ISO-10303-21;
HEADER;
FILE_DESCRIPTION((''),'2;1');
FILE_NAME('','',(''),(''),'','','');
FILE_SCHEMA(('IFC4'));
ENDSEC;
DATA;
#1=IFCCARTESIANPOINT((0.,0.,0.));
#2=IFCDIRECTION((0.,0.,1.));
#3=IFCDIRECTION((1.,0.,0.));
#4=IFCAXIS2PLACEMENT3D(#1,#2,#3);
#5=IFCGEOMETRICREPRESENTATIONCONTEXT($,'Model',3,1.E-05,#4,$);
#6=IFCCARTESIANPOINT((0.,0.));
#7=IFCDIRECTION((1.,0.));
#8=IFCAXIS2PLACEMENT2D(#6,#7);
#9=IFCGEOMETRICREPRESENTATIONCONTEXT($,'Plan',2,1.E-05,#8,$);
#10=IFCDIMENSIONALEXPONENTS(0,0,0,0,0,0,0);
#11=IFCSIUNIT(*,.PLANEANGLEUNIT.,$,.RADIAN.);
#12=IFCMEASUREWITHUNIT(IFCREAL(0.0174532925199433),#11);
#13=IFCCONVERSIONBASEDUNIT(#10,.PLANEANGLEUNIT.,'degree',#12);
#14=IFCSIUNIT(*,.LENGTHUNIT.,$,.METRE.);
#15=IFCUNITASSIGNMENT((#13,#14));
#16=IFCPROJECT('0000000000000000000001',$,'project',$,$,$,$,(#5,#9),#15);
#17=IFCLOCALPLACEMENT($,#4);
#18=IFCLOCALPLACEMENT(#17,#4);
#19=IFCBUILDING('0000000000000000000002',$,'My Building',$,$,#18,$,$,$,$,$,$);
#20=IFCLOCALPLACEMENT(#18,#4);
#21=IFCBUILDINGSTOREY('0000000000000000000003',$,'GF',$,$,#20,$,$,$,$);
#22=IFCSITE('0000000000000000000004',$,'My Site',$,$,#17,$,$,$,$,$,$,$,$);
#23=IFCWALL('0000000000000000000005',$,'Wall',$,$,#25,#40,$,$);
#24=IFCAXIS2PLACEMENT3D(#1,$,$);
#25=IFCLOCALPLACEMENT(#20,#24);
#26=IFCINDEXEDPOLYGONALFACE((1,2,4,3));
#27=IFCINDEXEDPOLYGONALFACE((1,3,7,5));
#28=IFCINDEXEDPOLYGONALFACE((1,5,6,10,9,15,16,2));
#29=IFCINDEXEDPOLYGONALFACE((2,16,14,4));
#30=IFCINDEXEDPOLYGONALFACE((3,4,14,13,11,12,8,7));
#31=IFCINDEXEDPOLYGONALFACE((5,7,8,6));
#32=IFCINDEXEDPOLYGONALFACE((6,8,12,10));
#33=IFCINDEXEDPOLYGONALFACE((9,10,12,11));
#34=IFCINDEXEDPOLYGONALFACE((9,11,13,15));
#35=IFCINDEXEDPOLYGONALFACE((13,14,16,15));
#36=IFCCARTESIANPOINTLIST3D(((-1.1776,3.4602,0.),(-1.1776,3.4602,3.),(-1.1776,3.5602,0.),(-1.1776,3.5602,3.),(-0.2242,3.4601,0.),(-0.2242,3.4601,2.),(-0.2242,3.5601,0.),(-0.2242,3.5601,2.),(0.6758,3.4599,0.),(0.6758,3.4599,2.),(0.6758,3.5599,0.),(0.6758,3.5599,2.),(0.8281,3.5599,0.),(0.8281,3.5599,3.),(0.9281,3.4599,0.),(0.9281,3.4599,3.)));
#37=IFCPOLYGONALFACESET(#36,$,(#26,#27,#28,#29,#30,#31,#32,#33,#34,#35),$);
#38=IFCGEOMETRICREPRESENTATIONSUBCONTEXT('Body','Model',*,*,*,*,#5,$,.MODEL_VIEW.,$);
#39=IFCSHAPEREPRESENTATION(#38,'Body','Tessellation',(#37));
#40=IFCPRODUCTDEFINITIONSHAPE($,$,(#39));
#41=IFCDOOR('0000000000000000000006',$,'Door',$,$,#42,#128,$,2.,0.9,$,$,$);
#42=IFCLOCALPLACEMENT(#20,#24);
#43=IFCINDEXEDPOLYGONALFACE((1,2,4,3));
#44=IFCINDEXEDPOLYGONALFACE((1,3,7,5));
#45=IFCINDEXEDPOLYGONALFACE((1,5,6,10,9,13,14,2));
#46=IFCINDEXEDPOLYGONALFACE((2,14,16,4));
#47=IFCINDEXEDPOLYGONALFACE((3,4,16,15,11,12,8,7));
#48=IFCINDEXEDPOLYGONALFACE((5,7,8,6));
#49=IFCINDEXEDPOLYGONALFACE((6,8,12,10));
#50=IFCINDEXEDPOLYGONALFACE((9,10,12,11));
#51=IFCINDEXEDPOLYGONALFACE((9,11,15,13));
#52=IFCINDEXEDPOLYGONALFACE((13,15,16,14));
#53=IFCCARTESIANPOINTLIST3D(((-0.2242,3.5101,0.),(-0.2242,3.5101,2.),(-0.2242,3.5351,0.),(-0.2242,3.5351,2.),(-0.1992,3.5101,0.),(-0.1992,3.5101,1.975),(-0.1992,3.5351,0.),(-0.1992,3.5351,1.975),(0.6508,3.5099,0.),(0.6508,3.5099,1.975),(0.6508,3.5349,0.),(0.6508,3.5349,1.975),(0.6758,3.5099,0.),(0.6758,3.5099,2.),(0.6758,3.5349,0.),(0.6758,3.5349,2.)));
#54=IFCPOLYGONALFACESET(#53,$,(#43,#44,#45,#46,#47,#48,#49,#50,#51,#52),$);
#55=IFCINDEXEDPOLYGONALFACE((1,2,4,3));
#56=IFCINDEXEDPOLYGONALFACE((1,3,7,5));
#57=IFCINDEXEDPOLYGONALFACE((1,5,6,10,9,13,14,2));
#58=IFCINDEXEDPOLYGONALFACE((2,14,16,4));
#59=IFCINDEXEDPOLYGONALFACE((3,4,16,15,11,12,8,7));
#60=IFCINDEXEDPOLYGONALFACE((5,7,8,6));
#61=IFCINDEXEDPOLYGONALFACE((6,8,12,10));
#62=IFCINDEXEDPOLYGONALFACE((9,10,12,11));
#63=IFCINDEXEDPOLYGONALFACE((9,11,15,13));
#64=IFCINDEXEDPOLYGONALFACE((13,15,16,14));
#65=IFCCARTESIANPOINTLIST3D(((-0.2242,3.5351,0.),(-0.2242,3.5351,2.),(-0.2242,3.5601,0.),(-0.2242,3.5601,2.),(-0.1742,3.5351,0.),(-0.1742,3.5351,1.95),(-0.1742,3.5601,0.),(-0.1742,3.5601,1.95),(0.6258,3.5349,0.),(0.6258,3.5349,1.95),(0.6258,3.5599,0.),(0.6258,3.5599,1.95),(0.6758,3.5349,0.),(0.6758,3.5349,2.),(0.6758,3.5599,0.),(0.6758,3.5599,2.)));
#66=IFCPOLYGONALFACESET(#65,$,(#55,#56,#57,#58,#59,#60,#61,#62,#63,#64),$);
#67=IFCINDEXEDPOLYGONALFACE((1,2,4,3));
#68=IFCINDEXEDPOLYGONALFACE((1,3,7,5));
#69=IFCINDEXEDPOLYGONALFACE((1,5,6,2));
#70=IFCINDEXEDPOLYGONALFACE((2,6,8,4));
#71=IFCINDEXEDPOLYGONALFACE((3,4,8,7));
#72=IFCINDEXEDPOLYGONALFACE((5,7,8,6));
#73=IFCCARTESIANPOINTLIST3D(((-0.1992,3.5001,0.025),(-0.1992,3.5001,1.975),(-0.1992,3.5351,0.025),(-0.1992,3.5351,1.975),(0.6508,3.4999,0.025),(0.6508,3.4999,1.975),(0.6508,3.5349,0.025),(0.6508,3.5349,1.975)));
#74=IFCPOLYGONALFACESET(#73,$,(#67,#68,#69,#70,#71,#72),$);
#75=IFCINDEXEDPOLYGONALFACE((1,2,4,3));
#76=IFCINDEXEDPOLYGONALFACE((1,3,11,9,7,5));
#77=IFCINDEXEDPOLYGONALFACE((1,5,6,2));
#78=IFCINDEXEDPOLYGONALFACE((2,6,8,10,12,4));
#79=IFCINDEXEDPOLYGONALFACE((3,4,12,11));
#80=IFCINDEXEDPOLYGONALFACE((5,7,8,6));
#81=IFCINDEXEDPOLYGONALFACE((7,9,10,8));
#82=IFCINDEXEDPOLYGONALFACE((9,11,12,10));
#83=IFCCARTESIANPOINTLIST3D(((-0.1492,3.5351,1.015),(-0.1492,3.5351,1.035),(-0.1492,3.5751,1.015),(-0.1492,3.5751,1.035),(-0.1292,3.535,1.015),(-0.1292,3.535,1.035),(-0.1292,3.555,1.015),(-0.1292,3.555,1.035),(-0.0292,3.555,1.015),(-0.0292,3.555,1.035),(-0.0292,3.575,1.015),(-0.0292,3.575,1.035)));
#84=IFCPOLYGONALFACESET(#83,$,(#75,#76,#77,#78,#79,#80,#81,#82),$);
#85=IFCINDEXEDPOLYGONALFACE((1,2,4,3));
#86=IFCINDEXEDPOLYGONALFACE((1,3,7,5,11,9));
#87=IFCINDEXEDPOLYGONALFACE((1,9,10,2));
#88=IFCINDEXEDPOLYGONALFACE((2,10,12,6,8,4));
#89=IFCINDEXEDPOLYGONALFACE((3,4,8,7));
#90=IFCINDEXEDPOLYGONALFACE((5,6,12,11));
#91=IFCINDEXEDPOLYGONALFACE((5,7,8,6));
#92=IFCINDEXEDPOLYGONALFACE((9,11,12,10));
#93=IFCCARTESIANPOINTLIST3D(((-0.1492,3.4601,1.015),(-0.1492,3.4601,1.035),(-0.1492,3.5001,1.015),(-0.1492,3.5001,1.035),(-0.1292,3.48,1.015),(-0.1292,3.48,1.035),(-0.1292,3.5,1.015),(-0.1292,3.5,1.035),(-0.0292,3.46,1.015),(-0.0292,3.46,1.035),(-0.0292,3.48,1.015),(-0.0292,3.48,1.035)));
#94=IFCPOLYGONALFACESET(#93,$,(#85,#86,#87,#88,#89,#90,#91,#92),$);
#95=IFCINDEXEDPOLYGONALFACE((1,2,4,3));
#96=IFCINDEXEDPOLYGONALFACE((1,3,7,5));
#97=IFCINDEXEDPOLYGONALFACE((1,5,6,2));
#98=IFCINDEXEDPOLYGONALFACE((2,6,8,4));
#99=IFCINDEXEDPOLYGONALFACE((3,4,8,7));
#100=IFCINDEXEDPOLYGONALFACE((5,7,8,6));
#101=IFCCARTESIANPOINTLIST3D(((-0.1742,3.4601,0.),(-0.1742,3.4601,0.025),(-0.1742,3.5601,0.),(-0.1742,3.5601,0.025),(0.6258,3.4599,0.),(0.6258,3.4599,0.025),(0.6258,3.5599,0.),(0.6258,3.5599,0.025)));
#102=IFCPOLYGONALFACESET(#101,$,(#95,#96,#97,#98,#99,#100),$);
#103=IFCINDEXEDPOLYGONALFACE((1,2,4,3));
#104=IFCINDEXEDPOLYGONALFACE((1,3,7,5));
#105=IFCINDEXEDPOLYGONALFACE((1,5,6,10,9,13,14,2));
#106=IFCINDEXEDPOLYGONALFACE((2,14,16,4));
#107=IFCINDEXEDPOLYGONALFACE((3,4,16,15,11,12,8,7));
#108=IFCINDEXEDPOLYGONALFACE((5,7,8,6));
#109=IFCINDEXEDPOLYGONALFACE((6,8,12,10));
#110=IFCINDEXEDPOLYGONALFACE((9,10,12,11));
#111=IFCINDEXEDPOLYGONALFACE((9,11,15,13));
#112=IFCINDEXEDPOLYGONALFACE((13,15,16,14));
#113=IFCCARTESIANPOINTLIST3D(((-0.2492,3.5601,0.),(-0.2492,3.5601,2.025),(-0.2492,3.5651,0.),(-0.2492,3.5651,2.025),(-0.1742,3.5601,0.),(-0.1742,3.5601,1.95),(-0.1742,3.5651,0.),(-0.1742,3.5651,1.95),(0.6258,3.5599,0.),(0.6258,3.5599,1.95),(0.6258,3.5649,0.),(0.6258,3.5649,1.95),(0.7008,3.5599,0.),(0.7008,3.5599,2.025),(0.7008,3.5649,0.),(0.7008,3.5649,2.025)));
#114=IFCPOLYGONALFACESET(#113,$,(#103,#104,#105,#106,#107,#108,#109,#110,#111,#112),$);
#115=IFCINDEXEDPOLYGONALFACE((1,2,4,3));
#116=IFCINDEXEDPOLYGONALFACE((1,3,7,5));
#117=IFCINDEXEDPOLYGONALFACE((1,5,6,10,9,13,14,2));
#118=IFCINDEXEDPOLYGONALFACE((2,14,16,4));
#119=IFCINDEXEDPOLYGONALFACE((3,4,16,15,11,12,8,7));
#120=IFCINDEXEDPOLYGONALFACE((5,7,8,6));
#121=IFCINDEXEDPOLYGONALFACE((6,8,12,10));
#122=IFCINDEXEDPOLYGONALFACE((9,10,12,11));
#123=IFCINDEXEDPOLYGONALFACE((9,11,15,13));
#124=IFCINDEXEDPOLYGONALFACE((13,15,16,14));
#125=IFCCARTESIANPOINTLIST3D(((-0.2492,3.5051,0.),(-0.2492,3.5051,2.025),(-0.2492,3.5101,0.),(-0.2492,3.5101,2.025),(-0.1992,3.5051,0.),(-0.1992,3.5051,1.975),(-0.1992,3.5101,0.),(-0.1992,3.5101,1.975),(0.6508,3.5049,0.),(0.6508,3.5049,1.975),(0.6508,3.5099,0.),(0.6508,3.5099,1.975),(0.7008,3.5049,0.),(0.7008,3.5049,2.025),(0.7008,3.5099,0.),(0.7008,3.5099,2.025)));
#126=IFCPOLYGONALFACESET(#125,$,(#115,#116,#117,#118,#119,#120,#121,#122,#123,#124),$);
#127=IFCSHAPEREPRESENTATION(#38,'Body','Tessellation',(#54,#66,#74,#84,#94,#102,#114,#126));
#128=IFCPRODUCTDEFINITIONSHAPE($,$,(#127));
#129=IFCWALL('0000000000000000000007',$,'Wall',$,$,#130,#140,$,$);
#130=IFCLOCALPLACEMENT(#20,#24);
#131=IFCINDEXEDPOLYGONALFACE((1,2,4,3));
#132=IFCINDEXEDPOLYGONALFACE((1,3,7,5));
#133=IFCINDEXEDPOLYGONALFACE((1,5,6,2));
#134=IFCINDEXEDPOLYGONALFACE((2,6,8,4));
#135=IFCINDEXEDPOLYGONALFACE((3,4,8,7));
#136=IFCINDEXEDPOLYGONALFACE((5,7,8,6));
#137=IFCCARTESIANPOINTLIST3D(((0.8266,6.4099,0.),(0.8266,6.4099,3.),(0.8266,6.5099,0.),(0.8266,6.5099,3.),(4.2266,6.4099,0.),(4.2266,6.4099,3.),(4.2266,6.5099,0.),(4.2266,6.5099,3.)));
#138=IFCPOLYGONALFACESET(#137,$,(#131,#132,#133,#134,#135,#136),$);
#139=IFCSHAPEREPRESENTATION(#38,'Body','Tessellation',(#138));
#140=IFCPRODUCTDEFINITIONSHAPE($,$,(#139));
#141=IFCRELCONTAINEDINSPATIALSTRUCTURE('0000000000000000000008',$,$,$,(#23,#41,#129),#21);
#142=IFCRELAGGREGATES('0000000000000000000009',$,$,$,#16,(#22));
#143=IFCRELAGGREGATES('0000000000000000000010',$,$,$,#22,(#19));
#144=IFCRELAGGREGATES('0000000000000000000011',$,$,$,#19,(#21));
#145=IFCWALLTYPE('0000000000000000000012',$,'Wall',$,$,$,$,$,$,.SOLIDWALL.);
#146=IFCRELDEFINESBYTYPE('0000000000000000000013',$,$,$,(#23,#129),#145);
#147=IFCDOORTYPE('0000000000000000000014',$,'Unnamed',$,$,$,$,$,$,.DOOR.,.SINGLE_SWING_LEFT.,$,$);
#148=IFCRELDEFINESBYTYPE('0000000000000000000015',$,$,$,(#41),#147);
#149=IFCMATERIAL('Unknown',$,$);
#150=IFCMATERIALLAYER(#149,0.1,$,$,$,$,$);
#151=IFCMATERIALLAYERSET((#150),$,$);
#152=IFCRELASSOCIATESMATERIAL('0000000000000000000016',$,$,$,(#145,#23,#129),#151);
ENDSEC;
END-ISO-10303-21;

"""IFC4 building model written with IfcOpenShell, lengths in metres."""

from ifc_helpers import new_model, entity, si_unit, converted_unit, frame, origin_with_axes, origin_2d_with_axis, place, context, subcontext, project, spatial, line, indexed_curve, outline, extrude, shape, source, transform, mapped, material, layer, layer_set, layer_usage, type_object, type_shapes, element, fill, save


model = new_model("IFC4")

# Units and contexts
model_context = context("Model", 3, precision=1e-05, world=origin_with_axes())
plan_context = context("Plan", 2, precision=1e-05, world=origin_2d_with_axis())
body_context_1 = subcontext(model_context, "Body", "Model", "MODEL_VIEW")
body_context_2 = subcontext(plan_context, "Body", "Plan", "PLAN_VIEW")
ifc_project = project(units=[converted_unit("PLANEANGLEUNIT", "degree", entity("IfcReal", 0.0174532925199433), si_unit("PLANEANGLEUNIT", "RADIAN"), dimensions=[0, 0, 0, 0, 0, 0, 0]), si_unit("LENGTHUNIT", "METRE")], contexts=[model_context, plan_context])

# Site, building, storey
site_placement = place(None, origin_with_axes())
site = spatial("IfcSite", under=ifc_project, at=site_placement, Name="My Site")
building_placement = place(site_placement, origin_with_axes())
building = spatial("IfcBuilding", under=site, at=building_placement, Name="My Building")
storey_placement = place(building_placement, origin_with_axes())
storey = spatial("IfcBuildingStorey", under=building, at=storey_placement, Name="GF")

# Shared definitions
ifc_material = material(Name="Unknown")

# Shared definitions
ifc_layer_1 = layer(ifc_material, 0.1)
ifc_layer_set_1 = layer_set([ifc_layer_1])
wall_type = type_object("IfcWallType", Name="Wall", PredefinedType="SOLIDWALL", material=ifc_layer_set_1)
shared_shape_1 = source(origin_with_axes(), body_context_1, "Body", "SweptSolid", [
    extrude(outline(indexed_curve([(0.0, 0.0), (0.9, 0.0), (0.9, 2.0), (0.0, 2.0)], segments=[line(1, 2, 3, 4, 1)])), frame((0.0, -0.6, 0.0), z_axis=(0.0, -1.0, 0.0), x_axis=(1.0, 0.0, 0.0)), (0.0, 0.0, -1.0), 1.2),
])
door_type = type_object("IfcDoorType", Name="Unnamed", OperationType="SINGLE_SWING_LEFT", PredefinedType="DOOR")
shared_shape_2 = source(origin_with_axes(), body_context_1, "Body", "SweptSolid", [
    extrude(outline(indexed_curve([(0.0, 0.0), (0.0, 2.0), (0.9, 2.0), (0.9, 0.0), (0.875, 0.0), (0.875, 1.975), (0.025, 1.975), (0.025, 0.0)], segments=[line(1, 2, 3, 4, 5, 6, 7, 8, 1)])), frame((0.0, 0.025, 0.0), z_axis=(0.0, -1.0, 0.0), x_axis=(1.0, 0.0, 0.0)), (0.0, 0.0, -1.0), 0.025),
    extrude(outline(indexed_curve([(0.0, 0.0), (0.0, 2.0), (0.9, 2.0), (0.9, 0.0), (0.85, 0.0), (0.85, 1.95), (0.05, 1.95), (0.05, 0.0)], segments=[line(1, 2, 3, 4, 5, 6, 7, 8, 1)])), frame((0.0, 0.0, 0.0), z_axis=(0.0, -1.0, 0.0), x_axis=(1.0, 0.0, 0.0)), (0.0, 0.0, -1.0), 0.025),
    extrude(outline(indexed_curve([(0.0, 0.0), (0.85, 0.0), (0.85, 0.035), (0.0, 0.035)], segments=[line(1, 2, 3, 4, 1)])), frame((0.025, 0.025, 0.025), z_axis=(0.0, 0.0, 1.0), x_axis=(1.0, 0.0, 0.0)), (0.0, 0.0, 1.0), 1.95),
    extrude(outline(indexed_curve([(0.0, 0.0), (0.0, -0.04), (-0.12, -0.04), (-0.12, -0.02), (-0.02, -0.02), (-0.02, 0.0)], segments=[line(1, 2, 3, 4, 5, 6, 1)])), frame((0.825, 0.025, 1.015), z_axis=(0.0, 0.0, 1.0), x_axis=(1.0, 0.0, 0.0)), (0.0, 0.0, 1.0), 0.02),
    extrude(outline(indexed_curve([(0.0, 0.0), (0.0, 0.04), (-0.12, 0.04), (-0.12, 0.02), (-0.02, 0.02), (-0.02, 0.0)], segments=[line(1, 2, 3, 4, 5, 6, 1)])), frame((0.825, 0.06, 1.015), z_axis=(0.0, 0.0, 1.0), x_axis=(1.0, 0.0, 0.0)), (0.0, 0.0, 1.0), 0.02),
    extrude(outline(indexed_curve([(0.0, 0.0), (0.8, 0.0), (0.8, 0.1), (0.0, 0.1)], segments=[line(1, 2, 3, 4, 1)])), frame((0.05, 0.0, 0.0), z_axis=(0.0, 0.0, 1.0), x_axis=(1.0, 0.0, 0.0)), (0.0, 0.0, 1.0), 0.025),
    extrude(outline(indexed_curve([(0.0, 0.0), (0.0, 2.025), (0.95, 2.025), (0.95, 0.0), (0.875, 0.0), (0.875, 1.95), (0.075, 1.95), (0.075, 0.0)], segments=[line(1, 2, 3, 4, 5, 6, 7, 8, 1)])), frame((-0.025, -0.005, 0.0), z_axis=(0.0, -1.0, 0.0), x_axis=(1.0, 0.0, 0.0)), (0.0, 0.0, -1.0), 0.005),
    extrude(outline(indexed_curve([(0.0, 0.0), (0.0, 2.025), (0.95, 2.025), (0.95, 0.0), (0.9, 0.0), (0.9, 1.975), (0.05, 1.975), (0.05, 0.0)], segments=[line(1, 2, 3, 4, 5, 6, 7, 8, 1)])), frame((-0.025, 0.05, 0.0), z_axis=(0.0, -1.0, 0.0), x_axis=(1.0, 0.0, 0.0)), (0.0, 0.0, -1.0), 0.005),
])
shared_shape_3 = source(origin_with_axes(), body_context_2, "Body", "Curve2D", [
    entity("IfcIndexedPolyCurve", entity("IfcCartesianPointList2D", [[0.0, 0.0], [0.0, 0.05], [0.025, 0.05], [0.025, 0.025], [0.05, 0.025], [0.05, 0.0]]), [entity("IfcLineIndex", [1, 2, 3, 4, 5, 6, 1])]),
    entity("IfcIndexedPolyCurve", entity("IfcCartesianPointList2D", [[0.9, 0.0], [0.9, 0.05], [0.875, 0.05], [0.875, 0.025], [0.85, 0.025], [0.85, 0.0]]), [entity("IfcLineIndex", [1, 2, 3, 4, 5, 6, 1])]),
    entity("IfcTrimmedCurve", entity("IfcEllipse", entity("IfcAxis2Placement2D", entity("IfcCartesianPoint", [0.06, 0.05]), entity("IfcDirection", [1.0, 0.0])), 0.815, 0.85), [entity("IfcCartesianPoint", [0.875, 0.05])], [entity("IfcCartesianPoint", [0.06, 0.9])], True, "CARTESIAN"),
    entity("IfcIndexedPolyCurve", entity("IfcCartesianPointList2D", [[0.025, 0.05], [0.06, 0.05], [0.06, 0.9], [0.025, 0.9]]), [entity("IfcLineIndex", [1, 2, 3, 4, 1])]),
])
type_shapes(door_type, [shared_shape_2, shared_shape_3])

# Wall, opening, door
ifc_layer_usage_1 = layer_usage(ifc_layer_set_1, "AXIS2", "POSITIVE", 0.0)
wall_1_placement = place(storey_placement, frame((0.8281, 3.5599, 0.0), z_axis=(0.0, 0.0, 1.0), x_axis=(-1.0, 0.000162, 0.0)))
wall_1 = element("IfcWall", 1, at=wall_1_placement, inside=storey, type_object=wall_type, material=ifc_layer_usage_1, Name="Wall", context=body_context_1, shape_type="SweptSolid", body=[
    extrude(outline(indexed_curve([(0.0, 0.0), (-0.1, 0.1), (2.0056, 0.1), (2.0056, 0.0)], segments=[line(1, 2, 3, 4, 1)])), origin_with_axes(), (0.0, 0.0, 1.0), 3.0),
])
opening_1_placement = place(wall_1_placement, frame((0.1523, 0.0, 0.0), z_axis=(0.0, 0.0, 1.0), x_axis=(1.0, 0.0, 0.0)))
opening_1 = element("IfcOpeningElement", 2, at=opening_1_placement, cuts=wall_1, PredefinedType="OPENING", context=body_context_1, shape_type="MappedRepresentation", body=[
    mapped(shared_shape_1, transform((0.0, 0.0, 0.0), x_axis=(1.0, 0.0, 0.0), y_axis=(0.0, 1.0, 0.0), z_axis=(0.0, 0.0, 1.0), scale=1.0)),
])
door_1_placement = place(opening_1_placement, frame((0.0, 0.0, 0.0), z_axis=(0.0, 0.0, 1.0), x_axis=(1.0, 0.0, 0.0)))
door_1 = element("IfcDoor", 3, at=door_1_placement, inside=storey, type_object=door_type, Name="Door", OverallHeight=2.0, OverallWidth=0.9, shapes=[
    shape(body_context_1, "Body", "MappedRepresentation", [mapped(shared_shape_2, transform((0.0, 0.0, 0.0), x_axis=(1.0, 0.0, 0.0), y_axis=(0.0, 1.0, 0.0), z_axis=(0.0, 0.0, 1.0), scale=1.0))]),
    shape(body_context_2, "Body", "MappedRepresentation", [mapped(shared_shape_3, transform((0.0, 0.0, 0.0), x_axis=(1.0, 0.0, 0.0), y_axis=(0.0, 1.0, 0.0), z_axis=(0.0, 0.0, 1.0), scale=1.0))]),
])
fill(opening_1, door_1)

# Wall
ifc_layer_usage_2 = layer_usage(ifc_layer_set_1, "AXIS2", "POSITIVE", 0.0)
wall_2_placement = place(storey_placement, frame((4.2266, 6.5099, 0.0), z_axis=(0.0, 0.0, 1.0), x_axis=(-1.0, 0.0, 0.0)))
element("IfcWall", 4, at=wall_2_placement, inside=storey, type_object=wall_type, material=ifc_layer_usage_2, Name="Wall", context=body_context_1, shape_type="SweptSolid", body=[
    extrude(outline(indexed_curve([(0.0, 0.0), (0.0, 0.1), (3.4, 0.1), (3.4, 0.0)], segments=[line(1, 2, 3, 4, 1)])), origin_with_axes(), (0.0, 0.0, 1.0), 3.0),
])

save(model, "model.ifc")
